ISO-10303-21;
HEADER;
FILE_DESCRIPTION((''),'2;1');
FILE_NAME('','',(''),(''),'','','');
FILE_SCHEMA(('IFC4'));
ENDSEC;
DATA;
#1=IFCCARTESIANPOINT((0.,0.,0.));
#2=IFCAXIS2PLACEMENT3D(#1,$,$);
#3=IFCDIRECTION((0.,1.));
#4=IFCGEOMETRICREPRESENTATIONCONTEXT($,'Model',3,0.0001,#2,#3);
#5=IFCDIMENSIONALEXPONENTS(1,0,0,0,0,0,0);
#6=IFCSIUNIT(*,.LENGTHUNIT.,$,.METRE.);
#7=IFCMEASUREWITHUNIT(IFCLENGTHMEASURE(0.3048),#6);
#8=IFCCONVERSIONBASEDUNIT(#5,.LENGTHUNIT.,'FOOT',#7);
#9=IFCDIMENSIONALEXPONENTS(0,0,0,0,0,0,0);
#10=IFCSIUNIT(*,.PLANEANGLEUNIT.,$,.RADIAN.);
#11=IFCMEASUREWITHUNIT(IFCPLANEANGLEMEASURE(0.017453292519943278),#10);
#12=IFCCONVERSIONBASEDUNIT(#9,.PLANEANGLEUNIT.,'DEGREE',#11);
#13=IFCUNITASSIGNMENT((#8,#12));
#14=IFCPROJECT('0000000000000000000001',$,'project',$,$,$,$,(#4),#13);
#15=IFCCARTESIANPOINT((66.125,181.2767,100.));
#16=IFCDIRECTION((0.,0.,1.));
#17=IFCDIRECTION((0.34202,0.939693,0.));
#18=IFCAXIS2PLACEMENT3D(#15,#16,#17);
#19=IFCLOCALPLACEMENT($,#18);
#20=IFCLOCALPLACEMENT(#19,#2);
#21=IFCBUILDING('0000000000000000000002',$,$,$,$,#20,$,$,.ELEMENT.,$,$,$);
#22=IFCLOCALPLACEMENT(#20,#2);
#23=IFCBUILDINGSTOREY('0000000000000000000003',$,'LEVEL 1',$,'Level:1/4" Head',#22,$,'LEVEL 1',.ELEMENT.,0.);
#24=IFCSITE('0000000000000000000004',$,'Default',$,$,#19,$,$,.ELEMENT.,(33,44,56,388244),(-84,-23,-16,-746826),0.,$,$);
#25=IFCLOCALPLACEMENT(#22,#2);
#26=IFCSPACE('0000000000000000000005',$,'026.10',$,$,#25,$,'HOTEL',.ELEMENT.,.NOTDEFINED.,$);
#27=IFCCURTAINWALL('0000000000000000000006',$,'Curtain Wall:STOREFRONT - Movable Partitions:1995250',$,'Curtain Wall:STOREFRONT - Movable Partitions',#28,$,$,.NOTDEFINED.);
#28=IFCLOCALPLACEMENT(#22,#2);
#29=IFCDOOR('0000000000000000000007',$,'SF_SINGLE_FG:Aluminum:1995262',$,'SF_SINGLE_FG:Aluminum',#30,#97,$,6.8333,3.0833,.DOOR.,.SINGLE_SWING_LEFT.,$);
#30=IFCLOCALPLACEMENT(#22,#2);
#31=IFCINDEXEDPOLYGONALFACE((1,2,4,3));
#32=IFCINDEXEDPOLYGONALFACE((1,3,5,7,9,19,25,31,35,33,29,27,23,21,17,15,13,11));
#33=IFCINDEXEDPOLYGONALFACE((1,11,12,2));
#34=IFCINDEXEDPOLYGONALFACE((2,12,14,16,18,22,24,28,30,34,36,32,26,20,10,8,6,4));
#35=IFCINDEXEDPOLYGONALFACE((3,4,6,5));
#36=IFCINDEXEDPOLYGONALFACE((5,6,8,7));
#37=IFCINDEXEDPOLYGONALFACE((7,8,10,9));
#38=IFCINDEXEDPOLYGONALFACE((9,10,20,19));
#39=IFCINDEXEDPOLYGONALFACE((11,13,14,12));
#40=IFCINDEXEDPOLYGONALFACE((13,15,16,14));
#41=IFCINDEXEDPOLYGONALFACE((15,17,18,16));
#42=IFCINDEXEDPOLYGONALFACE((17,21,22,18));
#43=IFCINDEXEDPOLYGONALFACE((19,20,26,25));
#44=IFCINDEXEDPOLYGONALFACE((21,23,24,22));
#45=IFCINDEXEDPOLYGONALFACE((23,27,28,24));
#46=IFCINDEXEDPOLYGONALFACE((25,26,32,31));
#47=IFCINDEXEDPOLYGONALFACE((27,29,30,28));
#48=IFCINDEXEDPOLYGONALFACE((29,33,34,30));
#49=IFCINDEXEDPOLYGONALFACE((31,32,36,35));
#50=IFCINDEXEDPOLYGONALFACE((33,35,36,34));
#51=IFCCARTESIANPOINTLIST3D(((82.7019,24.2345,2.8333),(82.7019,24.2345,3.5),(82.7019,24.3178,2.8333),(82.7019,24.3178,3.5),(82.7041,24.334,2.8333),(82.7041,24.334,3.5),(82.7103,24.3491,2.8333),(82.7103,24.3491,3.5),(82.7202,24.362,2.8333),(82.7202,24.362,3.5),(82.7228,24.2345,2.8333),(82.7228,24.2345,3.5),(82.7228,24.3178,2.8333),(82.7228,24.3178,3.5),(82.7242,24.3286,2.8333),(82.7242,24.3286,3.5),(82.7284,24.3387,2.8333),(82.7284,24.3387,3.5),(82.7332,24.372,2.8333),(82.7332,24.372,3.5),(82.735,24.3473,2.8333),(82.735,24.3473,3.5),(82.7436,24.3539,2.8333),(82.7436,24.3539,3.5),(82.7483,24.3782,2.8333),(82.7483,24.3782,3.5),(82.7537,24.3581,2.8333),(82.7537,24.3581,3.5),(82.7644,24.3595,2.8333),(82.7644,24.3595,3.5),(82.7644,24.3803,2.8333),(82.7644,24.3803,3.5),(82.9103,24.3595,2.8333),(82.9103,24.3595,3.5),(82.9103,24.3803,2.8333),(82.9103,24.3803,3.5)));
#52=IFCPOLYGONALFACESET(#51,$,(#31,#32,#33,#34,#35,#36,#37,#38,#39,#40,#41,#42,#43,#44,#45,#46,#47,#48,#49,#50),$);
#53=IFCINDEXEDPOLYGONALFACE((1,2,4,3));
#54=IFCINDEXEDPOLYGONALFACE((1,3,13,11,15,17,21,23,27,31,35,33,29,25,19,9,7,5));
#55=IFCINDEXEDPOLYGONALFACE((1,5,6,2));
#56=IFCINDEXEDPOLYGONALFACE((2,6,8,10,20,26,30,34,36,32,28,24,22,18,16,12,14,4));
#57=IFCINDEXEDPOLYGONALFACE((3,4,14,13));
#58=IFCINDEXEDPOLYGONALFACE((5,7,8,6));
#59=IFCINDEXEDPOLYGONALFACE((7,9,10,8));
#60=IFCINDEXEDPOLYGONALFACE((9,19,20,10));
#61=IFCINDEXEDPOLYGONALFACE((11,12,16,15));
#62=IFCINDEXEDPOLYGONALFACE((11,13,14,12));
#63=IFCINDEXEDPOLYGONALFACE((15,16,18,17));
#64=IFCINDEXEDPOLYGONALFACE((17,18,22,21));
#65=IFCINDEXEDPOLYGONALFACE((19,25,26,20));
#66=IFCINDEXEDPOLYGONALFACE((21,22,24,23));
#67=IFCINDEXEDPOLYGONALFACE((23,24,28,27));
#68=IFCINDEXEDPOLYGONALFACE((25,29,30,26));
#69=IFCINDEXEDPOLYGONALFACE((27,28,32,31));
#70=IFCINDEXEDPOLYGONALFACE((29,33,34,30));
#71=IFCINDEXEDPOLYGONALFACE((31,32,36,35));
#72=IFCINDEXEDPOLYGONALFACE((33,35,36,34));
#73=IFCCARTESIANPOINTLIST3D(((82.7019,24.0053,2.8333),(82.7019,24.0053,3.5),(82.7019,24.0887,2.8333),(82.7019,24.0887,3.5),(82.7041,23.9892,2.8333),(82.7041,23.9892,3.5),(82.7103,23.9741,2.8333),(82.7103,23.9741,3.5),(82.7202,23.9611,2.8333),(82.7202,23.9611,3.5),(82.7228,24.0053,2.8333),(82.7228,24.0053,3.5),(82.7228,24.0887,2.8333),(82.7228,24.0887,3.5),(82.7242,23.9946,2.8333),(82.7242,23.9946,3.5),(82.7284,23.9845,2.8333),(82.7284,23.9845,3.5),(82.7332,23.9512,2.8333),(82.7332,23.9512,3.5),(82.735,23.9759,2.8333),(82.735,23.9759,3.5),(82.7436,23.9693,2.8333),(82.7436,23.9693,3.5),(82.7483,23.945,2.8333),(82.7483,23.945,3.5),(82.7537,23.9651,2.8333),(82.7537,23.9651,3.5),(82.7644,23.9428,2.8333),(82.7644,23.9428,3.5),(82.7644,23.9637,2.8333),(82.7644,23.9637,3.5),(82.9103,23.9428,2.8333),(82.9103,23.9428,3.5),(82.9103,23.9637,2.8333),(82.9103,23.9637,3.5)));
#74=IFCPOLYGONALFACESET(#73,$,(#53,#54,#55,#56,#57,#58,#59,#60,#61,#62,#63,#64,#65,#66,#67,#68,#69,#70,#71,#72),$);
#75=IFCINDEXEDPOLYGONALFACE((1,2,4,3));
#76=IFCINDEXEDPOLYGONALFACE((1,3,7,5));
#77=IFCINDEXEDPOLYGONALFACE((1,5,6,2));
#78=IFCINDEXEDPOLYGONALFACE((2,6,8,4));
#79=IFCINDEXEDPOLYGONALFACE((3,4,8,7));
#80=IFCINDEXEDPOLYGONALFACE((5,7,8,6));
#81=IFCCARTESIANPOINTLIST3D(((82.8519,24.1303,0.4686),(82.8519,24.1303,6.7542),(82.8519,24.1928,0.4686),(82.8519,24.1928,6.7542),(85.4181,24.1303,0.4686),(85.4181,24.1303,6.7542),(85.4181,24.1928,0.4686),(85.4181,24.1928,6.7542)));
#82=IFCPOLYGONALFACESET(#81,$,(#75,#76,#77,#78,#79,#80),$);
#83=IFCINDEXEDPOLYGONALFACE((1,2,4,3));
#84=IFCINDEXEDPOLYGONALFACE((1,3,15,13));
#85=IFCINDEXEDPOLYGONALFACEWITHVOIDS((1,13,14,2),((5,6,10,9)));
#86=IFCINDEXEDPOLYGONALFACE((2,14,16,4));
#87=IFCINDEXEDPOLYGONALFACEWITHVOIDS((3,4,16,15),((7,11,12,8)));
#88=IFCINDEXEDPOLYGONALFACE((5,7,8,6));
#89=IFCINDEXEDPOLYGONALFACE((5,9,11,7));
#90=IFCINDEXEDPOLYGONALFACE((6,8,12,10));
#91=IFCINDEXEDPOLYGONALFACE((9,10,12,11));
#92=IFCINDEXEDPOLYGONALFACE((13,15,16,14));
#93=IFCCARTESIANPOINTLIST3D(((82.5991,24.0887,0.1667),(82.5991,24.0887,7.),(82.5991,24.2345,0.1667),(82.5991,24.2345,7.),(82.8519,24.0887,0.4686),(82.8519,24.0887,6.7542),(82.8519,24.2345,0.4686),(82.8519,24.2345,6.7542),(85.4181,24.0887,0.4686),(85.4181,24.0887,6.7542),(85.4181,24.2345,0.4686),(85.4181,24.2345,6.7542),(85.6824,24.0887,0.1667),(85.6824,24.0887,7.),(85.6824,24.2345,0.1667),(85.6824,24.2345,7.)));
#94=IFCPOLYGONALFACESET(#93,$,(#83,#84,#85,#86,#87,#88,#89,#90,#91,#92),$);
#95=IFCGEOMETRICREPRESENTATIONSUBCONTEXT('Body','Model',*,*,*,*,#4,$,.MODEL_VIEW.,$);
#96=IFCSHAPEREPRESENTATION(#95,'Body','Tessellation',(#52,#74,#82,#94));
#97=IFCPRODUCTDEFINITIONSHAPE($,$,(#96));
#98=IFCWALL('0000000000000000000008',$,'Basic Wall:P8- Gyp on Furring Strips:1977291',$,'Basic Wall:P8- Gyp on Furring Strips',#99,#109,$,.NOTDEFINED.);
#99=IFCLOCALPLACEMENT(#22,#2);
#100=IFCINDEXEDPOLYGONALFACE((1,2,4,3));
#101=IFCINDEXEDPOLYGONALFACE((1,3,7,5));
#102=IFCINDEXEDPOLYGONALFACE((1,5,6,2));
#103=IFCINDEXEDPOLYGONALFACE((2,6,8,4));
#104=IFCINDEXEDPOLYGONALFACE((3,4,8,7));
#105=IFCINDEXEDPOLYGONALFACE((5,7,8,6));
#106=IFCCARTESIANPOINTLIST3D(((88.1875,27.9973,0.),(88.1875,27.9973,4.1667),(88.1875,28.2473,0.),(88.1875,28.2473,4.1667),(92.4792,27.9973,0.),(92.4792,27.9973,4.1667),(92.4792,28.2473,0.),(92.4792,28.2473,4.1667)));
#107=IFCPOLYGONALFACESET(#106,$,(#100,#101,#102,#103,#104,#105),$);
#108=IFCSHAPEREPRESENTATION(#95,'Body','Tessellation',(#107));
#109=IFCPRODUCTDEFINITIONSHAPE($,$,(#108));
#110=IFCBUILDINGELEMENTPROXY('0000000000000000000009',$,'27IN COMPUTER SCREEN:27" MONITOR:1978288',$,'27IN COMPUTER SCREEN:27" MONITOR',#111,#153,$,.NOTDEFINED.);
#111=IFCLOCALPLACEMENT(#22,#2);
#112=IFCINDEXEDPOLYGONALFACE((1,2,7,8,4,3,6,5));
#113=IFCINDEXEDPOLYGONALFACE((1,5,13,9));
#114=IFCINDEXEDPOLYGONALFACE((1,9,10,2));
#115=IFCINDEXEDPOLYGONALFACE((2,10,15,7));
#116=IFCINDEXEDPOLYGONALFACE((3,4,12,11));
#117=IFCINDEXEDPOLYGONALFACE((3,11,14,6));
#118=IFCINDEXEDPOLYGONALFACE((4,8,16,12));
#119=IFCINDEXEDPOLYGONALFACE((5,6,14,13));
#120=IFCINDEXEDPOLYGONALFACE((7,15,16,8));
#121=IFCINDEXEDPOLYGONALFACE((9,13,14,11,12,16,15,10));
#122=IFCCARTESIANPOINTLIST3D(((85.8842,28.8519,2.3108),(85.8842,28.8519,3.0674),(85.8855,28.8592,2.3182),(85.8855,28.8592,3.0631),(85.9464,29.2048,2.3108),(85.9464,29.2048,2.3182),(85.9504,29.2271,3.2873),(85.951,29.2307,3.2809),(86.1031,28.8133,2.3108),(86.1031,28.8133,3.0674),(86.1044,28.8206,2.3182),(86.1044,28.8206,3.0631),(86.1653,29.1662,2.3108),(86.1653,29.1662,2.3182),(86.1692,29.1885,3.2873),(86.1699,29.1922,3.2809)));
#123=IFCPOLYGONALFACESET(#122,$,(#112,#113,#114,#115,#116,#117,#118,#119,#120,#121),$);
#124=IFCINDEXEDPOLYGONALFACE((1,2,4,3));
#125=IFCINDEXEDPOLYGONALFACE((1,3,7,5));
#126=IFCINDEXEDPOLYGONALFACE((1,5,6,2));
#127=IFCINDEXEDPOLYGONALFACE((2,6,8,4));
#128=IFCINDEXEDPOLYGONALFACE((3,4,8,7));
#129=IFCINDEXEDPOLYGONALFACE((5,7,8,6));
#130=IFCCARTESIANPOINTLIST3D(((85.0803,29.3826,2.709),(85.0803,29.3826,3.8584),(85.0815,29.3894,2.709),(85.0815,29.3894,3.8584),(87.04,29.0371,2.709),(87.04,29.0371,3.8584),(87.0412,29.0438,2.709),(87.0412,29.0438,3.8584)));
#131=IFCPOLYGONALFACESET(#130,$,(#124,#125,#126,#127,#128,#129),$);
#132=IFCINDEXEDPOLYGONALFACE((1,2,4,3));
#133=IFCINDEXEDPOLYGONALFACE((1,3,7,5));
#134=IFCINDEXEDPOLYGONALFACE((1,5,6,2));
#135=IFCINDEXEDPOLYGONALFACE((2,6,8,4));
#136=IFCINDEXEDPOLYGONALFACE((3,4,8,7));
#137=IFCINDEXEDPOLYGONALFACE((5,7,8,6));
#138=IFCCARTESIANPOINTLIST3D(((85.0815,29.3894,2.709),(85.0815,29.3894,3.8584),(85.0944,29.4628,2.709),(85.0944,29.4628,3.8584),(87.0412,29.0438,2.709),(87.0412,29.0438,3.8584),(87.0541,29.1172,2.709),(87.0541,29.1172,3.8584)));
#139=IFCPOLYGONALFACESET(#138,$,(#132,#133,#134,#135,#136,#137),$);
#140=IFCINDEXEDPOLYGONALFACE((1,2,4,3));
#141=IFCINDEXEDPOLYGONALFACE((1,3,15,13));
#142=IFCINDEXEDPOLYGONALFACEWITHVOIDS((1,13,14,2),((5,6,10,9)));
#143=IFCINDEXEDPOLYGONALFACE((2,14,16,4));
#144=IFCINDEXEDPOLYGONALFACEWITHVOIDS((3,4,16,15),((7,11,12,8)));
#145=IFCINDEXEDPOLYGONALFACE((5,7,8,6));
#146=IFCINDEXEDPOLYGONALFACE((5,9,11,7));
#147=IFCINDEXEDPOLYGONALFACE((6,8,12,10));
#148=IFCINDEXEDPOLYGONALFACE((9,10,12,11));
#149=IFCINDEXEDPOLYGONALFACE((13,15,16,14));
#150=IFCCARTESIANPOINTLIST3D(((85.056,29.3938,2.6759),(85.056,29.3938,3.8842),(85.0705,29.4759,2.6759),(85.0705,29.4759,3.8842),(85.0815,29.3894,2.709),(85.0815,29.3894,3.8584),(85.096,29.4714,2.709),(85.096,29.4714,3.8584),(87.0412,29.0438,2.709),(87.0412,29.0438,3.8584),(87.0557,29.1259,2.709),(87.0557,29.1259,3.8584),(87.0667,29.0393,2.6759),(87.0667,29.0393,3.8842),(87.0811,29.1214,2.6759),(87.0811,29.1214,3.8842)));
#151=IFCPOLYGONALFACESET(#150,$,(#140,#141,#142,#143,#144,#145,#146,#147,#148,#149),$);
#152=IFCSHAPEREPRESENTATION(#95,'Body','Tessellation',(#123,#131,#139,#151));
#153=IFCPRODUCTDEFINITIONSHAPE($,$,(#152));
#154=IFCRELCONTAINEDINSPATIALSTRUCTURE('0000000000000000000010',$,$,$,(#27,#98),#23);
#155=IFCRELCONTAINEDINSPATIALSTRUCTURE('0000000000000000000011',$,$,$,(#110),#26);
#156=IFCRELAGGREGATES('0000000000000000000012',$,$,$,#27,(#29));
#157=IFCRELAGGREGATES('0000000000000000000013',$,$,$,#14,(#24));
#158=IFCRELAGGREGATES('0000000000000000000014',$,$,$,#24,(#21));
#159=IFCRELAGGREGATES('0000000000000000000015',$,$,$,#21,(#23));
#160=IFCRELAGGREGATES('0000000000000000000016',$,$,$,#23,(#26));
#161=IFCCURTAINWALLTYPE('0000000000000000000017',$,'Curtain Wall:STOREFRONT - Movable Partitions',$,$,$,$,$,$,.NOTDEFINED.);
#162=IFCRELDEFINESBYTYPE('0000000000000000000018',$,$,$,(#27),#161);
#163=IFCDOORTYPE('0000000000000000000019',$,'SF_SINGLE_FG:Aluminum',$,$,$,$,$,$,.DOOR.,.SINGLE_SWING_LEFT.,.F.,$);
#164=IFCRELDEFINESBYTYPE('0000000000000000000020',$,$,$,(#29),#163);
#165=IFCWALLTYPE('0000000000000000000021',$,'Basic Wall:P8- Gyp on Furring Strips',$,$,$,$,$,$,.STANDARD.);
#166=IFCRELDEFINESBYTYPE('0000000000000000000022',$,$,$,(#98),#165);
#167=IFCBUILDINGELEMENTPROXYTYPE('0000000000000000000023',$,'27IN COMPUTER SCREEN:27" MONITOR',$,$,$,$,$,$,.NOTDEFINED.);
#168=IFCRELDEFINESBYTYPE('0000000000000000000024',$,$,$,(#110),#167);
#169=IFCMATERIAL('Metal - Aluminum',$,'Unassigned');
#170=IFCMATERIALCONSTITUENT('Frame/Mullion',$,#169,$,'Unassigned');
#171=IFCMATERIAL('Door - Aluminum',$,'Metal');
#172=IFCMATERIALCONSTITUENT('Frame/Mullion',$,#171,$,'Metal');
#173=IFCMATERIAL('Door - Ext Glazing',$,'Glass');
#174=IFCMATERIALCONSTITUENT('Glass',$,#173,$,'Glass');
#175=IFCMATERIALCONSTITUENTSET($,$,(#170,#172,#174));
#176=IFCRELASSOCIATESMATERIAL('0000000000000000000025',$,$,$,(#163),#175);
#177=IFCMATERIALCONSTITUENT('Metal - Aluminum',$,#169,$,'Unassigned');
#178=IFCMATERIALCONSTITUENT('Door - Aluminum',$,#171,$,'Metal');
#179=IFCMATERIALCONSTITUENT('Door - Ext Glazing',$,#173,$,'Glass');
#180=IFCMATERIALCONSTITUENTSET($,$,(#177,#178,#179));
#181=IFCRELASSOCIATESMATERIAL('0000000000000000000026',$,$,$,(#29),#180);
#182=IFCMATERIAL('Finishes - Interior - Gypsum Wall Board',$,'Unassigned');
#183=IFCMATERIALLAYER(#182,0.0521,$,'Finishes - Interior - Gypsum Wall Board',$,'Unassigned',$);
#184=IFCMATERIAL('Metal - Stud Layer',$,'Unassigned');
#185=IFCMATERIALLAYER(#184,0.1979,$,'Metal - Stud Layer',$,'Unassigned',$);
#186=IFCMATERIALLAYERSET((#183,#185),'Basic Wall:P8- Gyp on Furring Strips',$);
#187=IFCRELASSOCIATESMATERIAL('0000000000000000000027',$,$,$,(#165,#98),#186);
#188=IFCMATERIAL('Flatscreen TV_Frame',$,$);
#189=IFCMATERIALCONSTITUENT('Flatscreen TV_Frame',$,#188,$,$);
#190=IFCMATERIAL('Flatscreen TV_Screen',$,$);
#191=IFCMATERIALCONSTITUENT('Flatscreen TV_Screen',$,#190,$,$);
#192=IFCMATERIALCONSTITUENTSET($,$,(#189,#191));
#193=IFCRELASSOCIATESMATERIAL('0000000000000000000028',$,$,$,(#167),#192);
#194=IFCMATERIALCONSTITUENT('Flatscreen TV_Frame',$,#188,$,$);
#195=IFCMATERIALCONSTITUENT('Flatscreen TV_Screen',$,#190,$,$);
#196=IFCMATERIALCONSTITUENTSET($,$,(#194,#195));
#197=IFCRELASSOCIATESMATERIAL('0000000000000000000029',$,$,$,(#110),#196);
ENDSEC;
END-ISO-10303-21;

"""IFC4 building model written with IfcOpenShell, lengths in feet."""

from ifc_helpers import new_model, entity, si_unit, converted_unit, direction, frame, frame_2d, origin, origin_2d_with_axis, place, context, subcontext, project, spatial, polyline, circle_curve, parameter, trimmed, segment, composite_curve, rectangle, outline, extrude, source, transform, mapped, material, layer, layer_set, layer_usage, constituent, constituent_set, type_object, type_shapes, element, aggregate, save


model = new_model("IFC4")

# Units and contexts
model_context = context("Model", 3, precision=0.0001, world=origin(), true_north=direction((0.0, 1.0)))
body_context = subcontext(model_context, "Body", "Model", "MODEL_VIEW")
ifc_project = project(units=[converted_unit("LENGTHUNIT", "FOOT", entity("IfcLengthMeasure", 0.3048), si_unit("LENGTHUNIT", "METRE"), dimensions=[1, 0, 0, 0, 0, 0, 0]), converted_unit("PLANEANGLEUNIT", "DEGREE", entity("IfcPlaneAngleMeasure", 0.017453292519943278), si_unit("PLANEANGLEUNIT", "RADIAN"), dimensions=[0, 0, 0, 0, 0, 0, 0])], contexts=[model_context])

# Site, building, storey
site_placement = place(None, frame((66.125, 181.2767, 100.0), z_axis=(0.0, 0.0, 1.0), x_axis=(0.34202, 0.939693, 0.0)))
site = spatial("IfcSite", under=ifc_project, at=site_placement, Name="Default", CompositionType="ELEMENT", RefLatitude=(33, 44, 56, 388244), RefLongitude=(-84, -23, -16, -746826), RefElevation=0.0)
building_placement = place(site_placement, origin())
building = spatial("IfcBuilding", under=site, at=building_placement, CompositionType="ELEMENT")
storey_placement = place(building_placement, origin())
storey = spatial("IfcBuildingStorey", under=building, at=storey_placement, Name="LEVEL 1", ObjectType="Level:1/4\" Head", LongName="LEVEL 1", CompositionType="ELEMENT", Elevation=0.0)

# Curtain wall
curtain_wall_type = type_object("IfcCurtainWallType", Name="Curtain Wall:STOREFRONT - Movable Partitions", PredefinedType="NOTDEFINED")
curtain_wall_1_placement = place(storey_placement, origin())
curtain_wall_1 = element("IfcCurtainWall", 1, at=curtain_wall_1_placement, inside=storey, type_object=curtain_wall_type, Name="Curtain Wall:STOREFRONT - Movable Partitions:1995250", ObjectType="Curtain Wall:STOREFRONT - Movable Partitions", PredefinedType="NOTDEFINED")
ifc_material_1 = material(Name="Metal - Aluminum", Category="Unassigned")

# Door
ifc_constituent_1 = constituent(ifc_material_1, Name="Metal - Aluminum", Category="Unassigned")
ifc_material_2 = material(Name="Door - Aluminum", Category="Metal")
ifc_constituent_2 = constituent(ifc_material_2, Name="Door - Aluminum", Category="Metal")
ifc_material_3 = material(Name="Door - Ext Glazing", Category="Glass")
ifc_constituent_3 = constituent(ifc_material_3, Name="Door - Ext Glazing", Category="Glass")
ifc_constituent_set_1 = constituent_set(constituents=[ifc_constituent_1, ifc_constituent_2, ifc_constituent_3])
ifc_constituent_4 = constituent(ifc_material_1, Name="Frame/Mullion", Category="Unassigned")
ifc_constituent_5 = constituent(ifc_material_2, Name="Frame/Mullion", Category="Metal")
ifc_constituent_6 = constituent(ifc_material_3, Name="Glass", Category="Glass")
ifc_constituent_set_2 = constituent_set(constituents=[ifc_constituent_4, ifc_constituent_5, ifc_constituent_6])
door_type = type_object("IfcDoorType", Name="SF_SINGLE_FG:Aluminum", OperationType="SINGLE_SWING_LEFT", ParameterTakesPrecedence=False, PredefinedType="DOOR", material=ifc_constituent_set_2)
shared_shape_1 = source(origin(), body_context, "Body", "SweptSolid", [
    extrude(outline(composite_curve([segment(polyline([(0.0052, -0.0729), (0.0885, -0.0729)]), True, "CONTINUOUS"), segment(polyline([(0.0885, -0.0729), (0.0885, -0.0521)]), True, "CONTINUOUS"), segment(polyline([(0.0885, -0.0521), (0.0052, -0.0521)]), True, "CONTINUOUS"), segment(trimmed(circle_curve(frame_2d((0.0052, -0.0104), x_axis=(0.0, -1.0)), 0.0417), [parameter(270.0)], [parameter(0.0)], True, "PARAMETER"), False, "CONTINUOUS"), segment(polyline([(-0.0365, -0.0104), (-0.0365, 0.1354)]), True, "CONTINUOUS"), segment(polyline([(-0.0365, 0.1354), (-0.0573, 0.1354)]), True, "CONTINUOUS"), segment(polyline([(-0.0573, 0.1354), (-0.0573, -0.0104)]), True, "CONTINUOUS"), segment(trimmed(circle_curve(frame_2d((0.0052, -0.0104), x_axis=(0.0, -1.0)), 0.0625), [parameter(270.0)], [parameter(360.0)], True, "PARAMETER"), True, "CONTINUOUS")], self_intersect=False)), frame((1.3659, -0.0469, 2.6667), z_axis=(0.0, 0.0, 1.0), x_axis=(0.0, 1.0, 0.0)), (0.0, 0.0, 1.0), 0.6667),
    extrude(outline(composite_curve([segment(trimmed(circle_curve(frame_2d((0.0104, -0.0052), x_axis=(1.0, 0.0)), 0.0625), [parameter(0.0)], [parameter(90.0)], True, "PARAMETER"), True, "CONTINUOUS"), segment(polyline([(0.0104, 0.0573), (-0.1354, 0.0573)]), True, "CONTINUOUS"), segment(polyline([(-0.1354, 0.0573), (-0.1354, 0.0365)]), True, "CONTINUOUS"), segment(polyline([(-0.1354, 0.0365), (0.0104, 0.0365)]), True, "CONTINUOUS"), segment(trimmed(circle_curve(frame_2d((0.0104, -0.0052), x_axis=(1.0, 0.0)), 0.0417), [parameter(0.0)], [parameter(90.0)], True, "PARAMETER"), False, "CONTINUOUS"), segment(polyline([(0.0521, -0.0052), (0.0521, -0.0885)]), True, "CONTINUOUS"), segment(polyline([(0.0521, -0.0885), (0.0729, -0.0885)]), True, "CONTINUOUS"), segment(polyline([(0.0729, -0.0885), (0.0729, -0.0052)]), True, "CONTINUOUS")], self_intersect=False)), frame((1.3659, 0.276, 2.6667)), (0.0, 0.0, 1.0), 0.6667),
    extrude(rectangle(XDim=0.0625, YDim=2.5662, at=origin_2d_with_axis()), frame((0.0058, 0.1146, 0.3019), z_axis=(0.0, 0.0, 1.0), x_axis=(0.0, 1.0, 0.0)), (0.0, 0.0, 1.0), 6.2856),
    extrude(outline(polyline([(-3.4167, -1.5417), (3.4167, -1.5417), (3.4167, 1.5417), (-3.4167, 1.5417), (-3.4167, -1.5417)]), holes=[polyline([(-3.1709, 1.2773), (3.1147, 1.2773), (3.1147, -1.2889), (-3.1709, -1.2889), (-3.1709, 1.2773)])]), frame((0.0, 0.0417, 3.4167), z_axis=(0.0, 1.0, 0.0), x_axis=(0.0, 0.0, -1.0)), (0.0, 0.0, 1.0), 0.1458),
])
type_shapes(door_type, [shared_shape_1])
door_placement = place(curtain_wall_1_placement, frame((84.1407, 24.2762, 0.1667), z_axis=(0.0, 0.0, 1.0), x_axis=(-1.0, 0.0, 0.0)))
door = element("IfcDoor", 2, at=door_placement, type_object=door_type, material=ifc_constituent_set_1, Name="SF_SINGLE_FG:Aluminum:1995262", ObjectType="SF_SINGLE_FG:Aluminum", OperationType="SINGLE_SWING_LEFT", OverallHeight=6.8333, OverallWidth=3.0833, PredefinedType="DOOR", context=body_context, shape_type="MappedRepresentation", body=[
    mapped(shared_shape_1, transform((0.0, 0.0, 0.0), scale=1.0)),
])
aggregate(curtain_wall_1, [door])

# Wall
ifc_material_4 = material(Name="Finishes - Interior - Gypsum Wall Board", Category="Unassigned")
ifc_layer_1 = layer(ifc_material_4, 0.0521, Name="Finishes - Interior - Gypsum Wall Board", Category="Unassigned")
ifc_material_5 = material(Name="Metal - Stud Layer", Category="Unassigned")
ifc_layer_2 = layer(ifc_material_5, 0.1979, Name="Metal - Stud Layer", Category="Unassigned")
ifc_layer_set = layer_set([ifc_layer_1, ifc_layer_2], Name="Basic Wall:P8- Gyp on Furring Strips")
ifc_layer_usage = layer_usage(ifc_layer_set, "AXIS2", "NEGATIVE", 0.125)
wall_type = type_object("IfcWallType", Name="Basic Wall:P8- Gyp on Furring Strips", PredefinedType="STANDARD", material=ifc_layer_set)
wall_placement = place(storey_placement, frame((88.1875, 28.1223, 0.0)))
element("IfcWall", 3, at=wall_placement, inside=storey, type_object=wall_type, material=ifc_layer_usage, Name="Basic Wall:P8- Gyp on Furring Strips:1977291", ObjectType="Basic Wall:P8- Gyp on Furring Strips", PredefinedType="NOTDEFINED", context=body_context, shape_type="SweptSolid", body=[
    extrude(rectangle(XDim=4.2917, YDim=0.25, at=frame_2d((2.1458, 0.0), x_axis=(-1.0, 0.0))), origin(), (0.0, 0.0, 1.0), 4.1667),
])

# Shared definitions
space_1_placement = place(storey_placement, origin())
space_1 = spatial("IfcSpace", under=storey, at=space_1_placement, Name="026.10", LongName="HOTEL", CompositionType="ELEMENT", PredefinedType="NOTDEFINED")

# Building element proxy
ifc_material_6 = material(Name="Flatscreen TV_Frame")
ifc_constituent_7 = constituent(ifc_material_6, Name="Flatscreen TV_Frame")
ifc_material_7 = material(Name="Flatscreen TV_Screen")
ifc_constituent_8 = constituent(ifc_material_7, Name="Flatscreen TV_Screen")
ifc_constituent_set_3 = constituent_set(constituents=[ifc_constituent_7, ifc_constituent_8])
ifc_constituent_9 = constituent(ifc_material_6, Name="Flatscreen TV_Frame")
ifc_constituent_10 = constituent(ifc_material_7, Name="Flatscreen TV_Screen")
ifc_constituent_set_4 = constituent_set(constituents=[ifc_constituent_9, ifc_constituent_10])
building_element_proxy_type_1 = type_object("IfcBuildingElementProxyType", Name="27IN COMPUTER SCREEN:27\" MONITOR", PredefinedType="NOTDEFINED", material=ifc_constituent_set_4)
shared_shape_2 = source(origin(), body_context, "Body", "SweptSolid", [
    extrude(outline(polyline([(-0.4392, -0.3657), (-0.4392, -0.3731), (0.0007, -0.3731), (0.379, 0.2821), (0.0686, 0.4613), (0.0649, 0.4548), (0.3688, 0.2794), (-0.0036, -0.3657), (-0.4392, -0.3657)])), frame((-0.1111, -0.0264, 0.0687), z_axis=(-1.0, 0.0, 0.0), x_axis=(0.0, 0.866025, -0.5)), (0.0, 0.0, -1.0), 0.2222),
    extrude(rectangle(XDim=0.0068, YDim=1.9899, at=origin_2d_with_axis()), frame((0.0, -0.2257, 0.0331), z_axis=(0.0, 0.0, 1.0), x_axis=(0.0, 1.0, 0.0)), (0.0, 0.0, 1.0), 1.1493),
    extrude(rectangle(XDim=0.0746, YDim=1.9899, at=frame_2d((0.0, 0.0), x_axis=(1.0, 0.0))), frame((0.0, -0.2664, 0.0331), z_axis=(0.0, 0.0, 1.0), x_axis=(0.0, 1.0, 0.0)), (0.0, 0.0, 1.0), 1.1493),
    extrude(outline(polyline([(-0.6042, -1.0208), (0.6042, -1.0208), (0.6042, 1.0208), (-0.6042, 1.0208), (-0.6042, -1.0208)]), holes=[polyline([(-0.5783, -0.995), (-0.5783, 0.995), (0.571, 0.995), (0.571, -0.995), (-0.5783, -0.995)])]), frame((0.0, -0.3125, 0.6042), z_axis=(0.0, 1.0, 0.0), x_axis=(0.0, 0.0, -1.0)), (0.0, 0.0, 1.0), 0.0833),
])
type_shapes(building_element_proxy_type_1, [shared_shape_2])
proxy_1_placement = place(space_1_placement, frame((86.0216, 28.9909, 2.6759), z_axis=(0.0, 0.0, 1.0), x_axis=(-0.984808, 0.173648, 0.0)))
element("IfcBuildingElementProxy", 4, at=proxy_1_placement, inside=space_1, type_object=building_element_proxy_type_1, material=ifc_constituent_set_3, Name="27IN COMPUTER SCREEN:27\" MONITOR:1978288", ObjectType="27IN COMPUTER SCREEN:27\" MONITOR", PredefinedType="NOTDEFINED", context=body_context, shape_type="MappedRepresentation", body=[
    mapped(shared_shape_2, transform((0.0, 0.0, 0.0), scale=1.0)),
])

save(model, "model.ifc")
